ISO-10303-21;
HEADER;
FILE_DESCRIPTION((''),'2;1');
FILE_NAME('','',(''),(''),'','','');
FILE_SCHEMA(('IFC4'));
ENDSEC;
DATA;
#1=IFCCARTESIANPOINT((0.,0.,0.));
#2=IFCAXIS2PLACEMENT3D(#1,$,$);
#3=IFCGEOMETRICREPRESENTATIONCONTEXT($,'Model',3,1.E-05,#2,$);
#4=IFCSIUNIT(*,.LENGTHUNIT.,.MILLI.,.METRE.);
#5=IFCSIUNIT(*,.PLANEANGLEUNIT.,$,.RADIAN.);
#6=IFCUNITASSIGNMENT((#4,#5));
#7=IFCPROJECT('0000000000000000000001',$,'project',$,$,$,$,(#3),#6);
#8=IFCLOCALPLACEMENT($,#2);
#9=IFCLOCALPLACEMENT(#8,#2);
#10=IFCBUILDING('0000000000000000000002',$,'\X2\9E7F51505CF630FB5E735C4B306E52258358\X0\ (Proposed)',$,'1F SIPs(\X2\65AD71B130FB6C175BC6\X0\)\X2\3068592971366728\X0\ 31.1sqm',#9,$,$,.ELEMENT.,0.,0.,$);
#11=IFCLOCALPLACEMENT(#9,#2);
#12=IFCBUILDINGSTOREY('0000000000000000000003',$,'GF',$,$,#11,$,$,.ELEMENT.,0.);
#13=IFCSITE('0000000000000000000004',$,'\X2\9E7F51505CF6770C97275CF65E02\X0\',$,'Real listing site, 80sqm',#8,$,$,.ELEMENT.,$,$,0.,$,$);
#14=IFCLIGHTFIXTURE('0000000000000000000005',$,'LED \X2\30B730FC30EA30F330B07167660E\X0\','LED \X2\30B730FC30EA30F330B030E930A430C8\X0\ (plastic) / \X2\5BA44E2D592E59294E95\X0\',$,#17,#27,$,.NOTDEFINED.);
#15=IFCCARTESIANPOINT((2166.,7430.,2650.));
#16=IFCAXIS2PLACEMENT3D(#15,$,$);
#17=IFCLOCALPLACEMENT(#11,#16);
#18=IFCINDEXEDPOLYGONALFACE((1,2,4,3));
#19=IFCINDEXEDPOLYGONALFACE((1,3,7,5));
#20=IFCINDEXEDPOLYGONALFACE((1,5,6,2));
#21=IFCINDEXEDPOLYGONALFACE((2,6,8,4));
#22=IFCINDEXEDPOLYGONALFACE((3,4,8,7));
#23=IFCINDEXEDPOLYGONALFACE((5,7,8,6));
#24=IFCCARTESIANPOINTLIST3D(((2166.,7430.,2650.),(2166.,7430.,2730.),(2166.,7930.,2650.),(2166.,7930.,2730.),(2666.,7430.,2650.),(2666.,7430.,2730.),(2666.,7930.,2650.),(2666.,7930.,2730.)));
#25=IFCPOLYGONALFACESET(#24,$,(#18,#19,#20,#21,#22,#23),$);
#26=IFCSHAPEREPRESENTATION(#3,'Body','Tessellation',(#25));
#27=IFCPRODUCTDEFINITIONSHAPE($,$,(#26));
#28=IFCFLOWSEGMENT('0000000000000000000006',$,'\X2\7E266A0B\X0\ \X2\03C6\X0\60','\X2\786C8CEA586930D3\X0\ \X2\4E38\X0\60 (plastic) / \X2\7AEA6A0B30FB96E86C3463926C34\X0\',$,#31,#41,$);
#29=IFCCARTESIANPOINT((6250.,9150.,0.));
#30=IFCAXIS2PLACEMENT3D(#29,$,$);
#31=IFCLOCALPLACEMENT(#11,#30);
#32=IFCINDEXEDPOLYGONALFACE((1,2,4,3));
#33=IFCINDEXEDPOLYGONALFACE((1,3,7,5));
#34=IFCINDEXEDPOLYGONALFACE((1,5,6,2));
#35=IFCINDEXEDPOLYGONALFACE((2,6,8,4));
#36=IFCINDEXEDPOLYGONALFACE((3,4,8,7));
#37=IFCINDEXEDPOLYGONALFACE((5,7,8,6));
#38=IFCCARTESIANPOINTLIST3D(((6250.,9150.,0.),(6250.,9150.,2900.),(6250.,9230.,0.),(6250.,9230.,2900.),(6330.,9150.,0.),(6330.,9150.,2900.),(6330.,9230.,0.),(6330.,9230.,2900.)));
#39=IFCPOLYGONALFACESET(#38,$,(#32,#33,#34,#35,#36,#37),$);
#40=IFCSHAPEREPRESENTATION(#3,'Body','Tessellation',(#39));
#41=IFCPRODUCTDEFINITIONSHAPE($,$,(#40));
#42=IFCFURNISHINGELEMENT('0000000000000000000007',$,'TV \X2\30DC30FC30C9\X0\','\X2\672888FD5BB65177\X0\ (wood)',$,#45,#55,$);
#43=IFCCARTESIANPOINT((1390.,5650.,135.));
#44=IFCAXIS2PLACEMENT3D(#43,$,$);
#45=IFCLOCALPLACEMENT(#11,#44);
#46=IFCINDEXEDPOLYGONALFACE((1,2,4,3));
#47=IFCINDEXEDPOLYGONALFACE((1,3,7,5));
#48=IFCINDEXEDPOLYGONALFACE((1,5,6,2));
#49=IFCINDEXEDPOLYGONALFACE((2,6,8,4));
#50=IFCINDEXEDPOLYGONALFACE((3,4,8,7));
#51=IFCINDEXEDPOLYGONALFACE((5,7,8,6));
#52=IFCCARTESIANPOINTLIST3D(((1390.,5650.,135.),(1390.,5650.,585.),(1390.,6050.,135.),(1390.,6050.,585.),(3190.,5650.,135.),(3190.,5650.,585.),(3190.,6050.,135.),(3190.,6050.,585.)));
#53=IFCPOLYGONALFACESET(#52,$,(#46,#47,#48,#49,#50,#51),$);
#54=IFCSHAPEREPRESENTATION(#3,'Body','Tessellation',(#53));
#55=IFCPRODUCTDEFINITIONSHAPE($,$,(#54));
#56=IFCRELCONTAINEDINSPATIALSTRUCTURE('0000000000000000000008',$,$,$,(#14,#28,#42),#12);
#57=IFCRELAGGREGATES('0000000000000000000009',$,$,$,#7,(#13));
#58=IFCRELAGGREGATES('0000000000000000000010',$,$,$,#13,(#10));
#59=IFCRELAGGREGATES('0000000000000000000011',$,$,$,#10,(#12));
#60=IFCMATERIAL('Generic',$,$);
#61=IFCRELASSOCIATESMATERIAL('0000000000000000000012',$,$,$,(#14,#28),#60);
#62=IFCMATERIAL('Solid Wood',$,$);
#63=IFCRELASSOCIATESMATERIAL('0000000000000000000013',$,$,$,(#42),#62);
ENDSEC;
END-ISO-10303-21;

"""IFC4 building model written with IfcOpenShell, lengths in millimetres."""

from ifc_helpers import new_model, si_unit, frame, frame_2d, origin, place, context, project, spatial, rectangle, extrude, material, element, save


model = new_model("IFC4")

# Units and contexts
model_context = context("Model", 3, precision=1e-05, world=origin())
ifc_project = project(units=[si_unit("LENGTHUNIT", "METRE", prefix="MILLI"), si_unit("PLANEANGLEUNIT", "RADIAN")], contexts=[model_context])

# Site, building, storey
site_placement = place(None, origin())
site = spatial("IfcSite", under=ifc_project, at=site_placement, Name="鹿児島県霧島市", ObjectType="Real listing site, 80sqm", CompositionType="ELEMENT", RefElevation=0.0)
building_placement = place(site_placement, origin())
building = spatial("IfcBuilding", under=site, at=building_placement, Name="鹿児島・平屋の別荘 (Proposed)", ObjectType="1F SIPs(断熱・気密)と天然木 31.1sqm", CompositionType="ELEMENT", ElevationOfRefHeight=0.0, ElevationOfTerrain=0.0)
storey_placement = place(building_placement, origin())
storey = spatial("IfcBuildingStorey", under=building, at=storey_placement, Name="GF", CompositionType="ELEMENT", Elevation=0.0)

# Shared definitions
ifc_material_1 = material(Name="Solid Wood")

# Shared definitions
ifc_material_2 = material(Name="Generic")

# Light fixture
light_fixture_1_placement = place(storey_placement, frame((2166.0, 7430.0, 2650.0)))
element("IfcLightFixture", 1, at=light_fixture_1_placement, inside=storey, material=ifc_material_2, Name="LED シーリング照明", Description="LED シーリングライト (plastic) / 室中央天井", PredefinedType="NOTDEFINED", context=model_context, shape_type="SweptSolid", body=[
    extrude(rectangle(XDim=500.0, YDim=500.0, at=frame_2d((250.0, 250.0))), frame((2166.0, 7430.0, 2650.0)), (0.0, 0.0, 1.0), 80.0),
])

# Flow segment
flow_segment_placement = place(storey_placement, frame((6250.0, 9150.0, 0.0)))
element("IfcFlowSegment", 2, at=flow_segment_placement, inside=storey, material=ifc_material_2, Name="縦樋 φ60", Description="硬質塩ビ 丸60 (plastic) / 竪樋・雨水排水", context=model_context, shape_type="SweptSolid", body=[
    extrude(rectangle(XDim=80.0, YDim=80.0, at=frame_2d((40.0, 40.0))), frame((6250.0, 9150.0, 0.0)), (0.0, 0.0, 1.0), 2900.0),
])

# Furnishing element
furnishing_placement = place(storey_placement, frame((1390.0, 5650.0, 135.0)))
element("IfcFurnishingElement", 3, at=furnishing_placement, inside=storey, material=ifc_material_1, Name="TV ボード", Description="木製家具 (wood)", context=model_context, shape_type="SweptSolid", body=[
    extrude(rectangle(XDim=1800.0, YDim=400.0, at=frame_2d((900.0, 200.0))), frame((1390.0, 5650.0, 135.0)), (0.0, 0.0, 1.0), 450.0),
])

save(model, "model.ifc")
